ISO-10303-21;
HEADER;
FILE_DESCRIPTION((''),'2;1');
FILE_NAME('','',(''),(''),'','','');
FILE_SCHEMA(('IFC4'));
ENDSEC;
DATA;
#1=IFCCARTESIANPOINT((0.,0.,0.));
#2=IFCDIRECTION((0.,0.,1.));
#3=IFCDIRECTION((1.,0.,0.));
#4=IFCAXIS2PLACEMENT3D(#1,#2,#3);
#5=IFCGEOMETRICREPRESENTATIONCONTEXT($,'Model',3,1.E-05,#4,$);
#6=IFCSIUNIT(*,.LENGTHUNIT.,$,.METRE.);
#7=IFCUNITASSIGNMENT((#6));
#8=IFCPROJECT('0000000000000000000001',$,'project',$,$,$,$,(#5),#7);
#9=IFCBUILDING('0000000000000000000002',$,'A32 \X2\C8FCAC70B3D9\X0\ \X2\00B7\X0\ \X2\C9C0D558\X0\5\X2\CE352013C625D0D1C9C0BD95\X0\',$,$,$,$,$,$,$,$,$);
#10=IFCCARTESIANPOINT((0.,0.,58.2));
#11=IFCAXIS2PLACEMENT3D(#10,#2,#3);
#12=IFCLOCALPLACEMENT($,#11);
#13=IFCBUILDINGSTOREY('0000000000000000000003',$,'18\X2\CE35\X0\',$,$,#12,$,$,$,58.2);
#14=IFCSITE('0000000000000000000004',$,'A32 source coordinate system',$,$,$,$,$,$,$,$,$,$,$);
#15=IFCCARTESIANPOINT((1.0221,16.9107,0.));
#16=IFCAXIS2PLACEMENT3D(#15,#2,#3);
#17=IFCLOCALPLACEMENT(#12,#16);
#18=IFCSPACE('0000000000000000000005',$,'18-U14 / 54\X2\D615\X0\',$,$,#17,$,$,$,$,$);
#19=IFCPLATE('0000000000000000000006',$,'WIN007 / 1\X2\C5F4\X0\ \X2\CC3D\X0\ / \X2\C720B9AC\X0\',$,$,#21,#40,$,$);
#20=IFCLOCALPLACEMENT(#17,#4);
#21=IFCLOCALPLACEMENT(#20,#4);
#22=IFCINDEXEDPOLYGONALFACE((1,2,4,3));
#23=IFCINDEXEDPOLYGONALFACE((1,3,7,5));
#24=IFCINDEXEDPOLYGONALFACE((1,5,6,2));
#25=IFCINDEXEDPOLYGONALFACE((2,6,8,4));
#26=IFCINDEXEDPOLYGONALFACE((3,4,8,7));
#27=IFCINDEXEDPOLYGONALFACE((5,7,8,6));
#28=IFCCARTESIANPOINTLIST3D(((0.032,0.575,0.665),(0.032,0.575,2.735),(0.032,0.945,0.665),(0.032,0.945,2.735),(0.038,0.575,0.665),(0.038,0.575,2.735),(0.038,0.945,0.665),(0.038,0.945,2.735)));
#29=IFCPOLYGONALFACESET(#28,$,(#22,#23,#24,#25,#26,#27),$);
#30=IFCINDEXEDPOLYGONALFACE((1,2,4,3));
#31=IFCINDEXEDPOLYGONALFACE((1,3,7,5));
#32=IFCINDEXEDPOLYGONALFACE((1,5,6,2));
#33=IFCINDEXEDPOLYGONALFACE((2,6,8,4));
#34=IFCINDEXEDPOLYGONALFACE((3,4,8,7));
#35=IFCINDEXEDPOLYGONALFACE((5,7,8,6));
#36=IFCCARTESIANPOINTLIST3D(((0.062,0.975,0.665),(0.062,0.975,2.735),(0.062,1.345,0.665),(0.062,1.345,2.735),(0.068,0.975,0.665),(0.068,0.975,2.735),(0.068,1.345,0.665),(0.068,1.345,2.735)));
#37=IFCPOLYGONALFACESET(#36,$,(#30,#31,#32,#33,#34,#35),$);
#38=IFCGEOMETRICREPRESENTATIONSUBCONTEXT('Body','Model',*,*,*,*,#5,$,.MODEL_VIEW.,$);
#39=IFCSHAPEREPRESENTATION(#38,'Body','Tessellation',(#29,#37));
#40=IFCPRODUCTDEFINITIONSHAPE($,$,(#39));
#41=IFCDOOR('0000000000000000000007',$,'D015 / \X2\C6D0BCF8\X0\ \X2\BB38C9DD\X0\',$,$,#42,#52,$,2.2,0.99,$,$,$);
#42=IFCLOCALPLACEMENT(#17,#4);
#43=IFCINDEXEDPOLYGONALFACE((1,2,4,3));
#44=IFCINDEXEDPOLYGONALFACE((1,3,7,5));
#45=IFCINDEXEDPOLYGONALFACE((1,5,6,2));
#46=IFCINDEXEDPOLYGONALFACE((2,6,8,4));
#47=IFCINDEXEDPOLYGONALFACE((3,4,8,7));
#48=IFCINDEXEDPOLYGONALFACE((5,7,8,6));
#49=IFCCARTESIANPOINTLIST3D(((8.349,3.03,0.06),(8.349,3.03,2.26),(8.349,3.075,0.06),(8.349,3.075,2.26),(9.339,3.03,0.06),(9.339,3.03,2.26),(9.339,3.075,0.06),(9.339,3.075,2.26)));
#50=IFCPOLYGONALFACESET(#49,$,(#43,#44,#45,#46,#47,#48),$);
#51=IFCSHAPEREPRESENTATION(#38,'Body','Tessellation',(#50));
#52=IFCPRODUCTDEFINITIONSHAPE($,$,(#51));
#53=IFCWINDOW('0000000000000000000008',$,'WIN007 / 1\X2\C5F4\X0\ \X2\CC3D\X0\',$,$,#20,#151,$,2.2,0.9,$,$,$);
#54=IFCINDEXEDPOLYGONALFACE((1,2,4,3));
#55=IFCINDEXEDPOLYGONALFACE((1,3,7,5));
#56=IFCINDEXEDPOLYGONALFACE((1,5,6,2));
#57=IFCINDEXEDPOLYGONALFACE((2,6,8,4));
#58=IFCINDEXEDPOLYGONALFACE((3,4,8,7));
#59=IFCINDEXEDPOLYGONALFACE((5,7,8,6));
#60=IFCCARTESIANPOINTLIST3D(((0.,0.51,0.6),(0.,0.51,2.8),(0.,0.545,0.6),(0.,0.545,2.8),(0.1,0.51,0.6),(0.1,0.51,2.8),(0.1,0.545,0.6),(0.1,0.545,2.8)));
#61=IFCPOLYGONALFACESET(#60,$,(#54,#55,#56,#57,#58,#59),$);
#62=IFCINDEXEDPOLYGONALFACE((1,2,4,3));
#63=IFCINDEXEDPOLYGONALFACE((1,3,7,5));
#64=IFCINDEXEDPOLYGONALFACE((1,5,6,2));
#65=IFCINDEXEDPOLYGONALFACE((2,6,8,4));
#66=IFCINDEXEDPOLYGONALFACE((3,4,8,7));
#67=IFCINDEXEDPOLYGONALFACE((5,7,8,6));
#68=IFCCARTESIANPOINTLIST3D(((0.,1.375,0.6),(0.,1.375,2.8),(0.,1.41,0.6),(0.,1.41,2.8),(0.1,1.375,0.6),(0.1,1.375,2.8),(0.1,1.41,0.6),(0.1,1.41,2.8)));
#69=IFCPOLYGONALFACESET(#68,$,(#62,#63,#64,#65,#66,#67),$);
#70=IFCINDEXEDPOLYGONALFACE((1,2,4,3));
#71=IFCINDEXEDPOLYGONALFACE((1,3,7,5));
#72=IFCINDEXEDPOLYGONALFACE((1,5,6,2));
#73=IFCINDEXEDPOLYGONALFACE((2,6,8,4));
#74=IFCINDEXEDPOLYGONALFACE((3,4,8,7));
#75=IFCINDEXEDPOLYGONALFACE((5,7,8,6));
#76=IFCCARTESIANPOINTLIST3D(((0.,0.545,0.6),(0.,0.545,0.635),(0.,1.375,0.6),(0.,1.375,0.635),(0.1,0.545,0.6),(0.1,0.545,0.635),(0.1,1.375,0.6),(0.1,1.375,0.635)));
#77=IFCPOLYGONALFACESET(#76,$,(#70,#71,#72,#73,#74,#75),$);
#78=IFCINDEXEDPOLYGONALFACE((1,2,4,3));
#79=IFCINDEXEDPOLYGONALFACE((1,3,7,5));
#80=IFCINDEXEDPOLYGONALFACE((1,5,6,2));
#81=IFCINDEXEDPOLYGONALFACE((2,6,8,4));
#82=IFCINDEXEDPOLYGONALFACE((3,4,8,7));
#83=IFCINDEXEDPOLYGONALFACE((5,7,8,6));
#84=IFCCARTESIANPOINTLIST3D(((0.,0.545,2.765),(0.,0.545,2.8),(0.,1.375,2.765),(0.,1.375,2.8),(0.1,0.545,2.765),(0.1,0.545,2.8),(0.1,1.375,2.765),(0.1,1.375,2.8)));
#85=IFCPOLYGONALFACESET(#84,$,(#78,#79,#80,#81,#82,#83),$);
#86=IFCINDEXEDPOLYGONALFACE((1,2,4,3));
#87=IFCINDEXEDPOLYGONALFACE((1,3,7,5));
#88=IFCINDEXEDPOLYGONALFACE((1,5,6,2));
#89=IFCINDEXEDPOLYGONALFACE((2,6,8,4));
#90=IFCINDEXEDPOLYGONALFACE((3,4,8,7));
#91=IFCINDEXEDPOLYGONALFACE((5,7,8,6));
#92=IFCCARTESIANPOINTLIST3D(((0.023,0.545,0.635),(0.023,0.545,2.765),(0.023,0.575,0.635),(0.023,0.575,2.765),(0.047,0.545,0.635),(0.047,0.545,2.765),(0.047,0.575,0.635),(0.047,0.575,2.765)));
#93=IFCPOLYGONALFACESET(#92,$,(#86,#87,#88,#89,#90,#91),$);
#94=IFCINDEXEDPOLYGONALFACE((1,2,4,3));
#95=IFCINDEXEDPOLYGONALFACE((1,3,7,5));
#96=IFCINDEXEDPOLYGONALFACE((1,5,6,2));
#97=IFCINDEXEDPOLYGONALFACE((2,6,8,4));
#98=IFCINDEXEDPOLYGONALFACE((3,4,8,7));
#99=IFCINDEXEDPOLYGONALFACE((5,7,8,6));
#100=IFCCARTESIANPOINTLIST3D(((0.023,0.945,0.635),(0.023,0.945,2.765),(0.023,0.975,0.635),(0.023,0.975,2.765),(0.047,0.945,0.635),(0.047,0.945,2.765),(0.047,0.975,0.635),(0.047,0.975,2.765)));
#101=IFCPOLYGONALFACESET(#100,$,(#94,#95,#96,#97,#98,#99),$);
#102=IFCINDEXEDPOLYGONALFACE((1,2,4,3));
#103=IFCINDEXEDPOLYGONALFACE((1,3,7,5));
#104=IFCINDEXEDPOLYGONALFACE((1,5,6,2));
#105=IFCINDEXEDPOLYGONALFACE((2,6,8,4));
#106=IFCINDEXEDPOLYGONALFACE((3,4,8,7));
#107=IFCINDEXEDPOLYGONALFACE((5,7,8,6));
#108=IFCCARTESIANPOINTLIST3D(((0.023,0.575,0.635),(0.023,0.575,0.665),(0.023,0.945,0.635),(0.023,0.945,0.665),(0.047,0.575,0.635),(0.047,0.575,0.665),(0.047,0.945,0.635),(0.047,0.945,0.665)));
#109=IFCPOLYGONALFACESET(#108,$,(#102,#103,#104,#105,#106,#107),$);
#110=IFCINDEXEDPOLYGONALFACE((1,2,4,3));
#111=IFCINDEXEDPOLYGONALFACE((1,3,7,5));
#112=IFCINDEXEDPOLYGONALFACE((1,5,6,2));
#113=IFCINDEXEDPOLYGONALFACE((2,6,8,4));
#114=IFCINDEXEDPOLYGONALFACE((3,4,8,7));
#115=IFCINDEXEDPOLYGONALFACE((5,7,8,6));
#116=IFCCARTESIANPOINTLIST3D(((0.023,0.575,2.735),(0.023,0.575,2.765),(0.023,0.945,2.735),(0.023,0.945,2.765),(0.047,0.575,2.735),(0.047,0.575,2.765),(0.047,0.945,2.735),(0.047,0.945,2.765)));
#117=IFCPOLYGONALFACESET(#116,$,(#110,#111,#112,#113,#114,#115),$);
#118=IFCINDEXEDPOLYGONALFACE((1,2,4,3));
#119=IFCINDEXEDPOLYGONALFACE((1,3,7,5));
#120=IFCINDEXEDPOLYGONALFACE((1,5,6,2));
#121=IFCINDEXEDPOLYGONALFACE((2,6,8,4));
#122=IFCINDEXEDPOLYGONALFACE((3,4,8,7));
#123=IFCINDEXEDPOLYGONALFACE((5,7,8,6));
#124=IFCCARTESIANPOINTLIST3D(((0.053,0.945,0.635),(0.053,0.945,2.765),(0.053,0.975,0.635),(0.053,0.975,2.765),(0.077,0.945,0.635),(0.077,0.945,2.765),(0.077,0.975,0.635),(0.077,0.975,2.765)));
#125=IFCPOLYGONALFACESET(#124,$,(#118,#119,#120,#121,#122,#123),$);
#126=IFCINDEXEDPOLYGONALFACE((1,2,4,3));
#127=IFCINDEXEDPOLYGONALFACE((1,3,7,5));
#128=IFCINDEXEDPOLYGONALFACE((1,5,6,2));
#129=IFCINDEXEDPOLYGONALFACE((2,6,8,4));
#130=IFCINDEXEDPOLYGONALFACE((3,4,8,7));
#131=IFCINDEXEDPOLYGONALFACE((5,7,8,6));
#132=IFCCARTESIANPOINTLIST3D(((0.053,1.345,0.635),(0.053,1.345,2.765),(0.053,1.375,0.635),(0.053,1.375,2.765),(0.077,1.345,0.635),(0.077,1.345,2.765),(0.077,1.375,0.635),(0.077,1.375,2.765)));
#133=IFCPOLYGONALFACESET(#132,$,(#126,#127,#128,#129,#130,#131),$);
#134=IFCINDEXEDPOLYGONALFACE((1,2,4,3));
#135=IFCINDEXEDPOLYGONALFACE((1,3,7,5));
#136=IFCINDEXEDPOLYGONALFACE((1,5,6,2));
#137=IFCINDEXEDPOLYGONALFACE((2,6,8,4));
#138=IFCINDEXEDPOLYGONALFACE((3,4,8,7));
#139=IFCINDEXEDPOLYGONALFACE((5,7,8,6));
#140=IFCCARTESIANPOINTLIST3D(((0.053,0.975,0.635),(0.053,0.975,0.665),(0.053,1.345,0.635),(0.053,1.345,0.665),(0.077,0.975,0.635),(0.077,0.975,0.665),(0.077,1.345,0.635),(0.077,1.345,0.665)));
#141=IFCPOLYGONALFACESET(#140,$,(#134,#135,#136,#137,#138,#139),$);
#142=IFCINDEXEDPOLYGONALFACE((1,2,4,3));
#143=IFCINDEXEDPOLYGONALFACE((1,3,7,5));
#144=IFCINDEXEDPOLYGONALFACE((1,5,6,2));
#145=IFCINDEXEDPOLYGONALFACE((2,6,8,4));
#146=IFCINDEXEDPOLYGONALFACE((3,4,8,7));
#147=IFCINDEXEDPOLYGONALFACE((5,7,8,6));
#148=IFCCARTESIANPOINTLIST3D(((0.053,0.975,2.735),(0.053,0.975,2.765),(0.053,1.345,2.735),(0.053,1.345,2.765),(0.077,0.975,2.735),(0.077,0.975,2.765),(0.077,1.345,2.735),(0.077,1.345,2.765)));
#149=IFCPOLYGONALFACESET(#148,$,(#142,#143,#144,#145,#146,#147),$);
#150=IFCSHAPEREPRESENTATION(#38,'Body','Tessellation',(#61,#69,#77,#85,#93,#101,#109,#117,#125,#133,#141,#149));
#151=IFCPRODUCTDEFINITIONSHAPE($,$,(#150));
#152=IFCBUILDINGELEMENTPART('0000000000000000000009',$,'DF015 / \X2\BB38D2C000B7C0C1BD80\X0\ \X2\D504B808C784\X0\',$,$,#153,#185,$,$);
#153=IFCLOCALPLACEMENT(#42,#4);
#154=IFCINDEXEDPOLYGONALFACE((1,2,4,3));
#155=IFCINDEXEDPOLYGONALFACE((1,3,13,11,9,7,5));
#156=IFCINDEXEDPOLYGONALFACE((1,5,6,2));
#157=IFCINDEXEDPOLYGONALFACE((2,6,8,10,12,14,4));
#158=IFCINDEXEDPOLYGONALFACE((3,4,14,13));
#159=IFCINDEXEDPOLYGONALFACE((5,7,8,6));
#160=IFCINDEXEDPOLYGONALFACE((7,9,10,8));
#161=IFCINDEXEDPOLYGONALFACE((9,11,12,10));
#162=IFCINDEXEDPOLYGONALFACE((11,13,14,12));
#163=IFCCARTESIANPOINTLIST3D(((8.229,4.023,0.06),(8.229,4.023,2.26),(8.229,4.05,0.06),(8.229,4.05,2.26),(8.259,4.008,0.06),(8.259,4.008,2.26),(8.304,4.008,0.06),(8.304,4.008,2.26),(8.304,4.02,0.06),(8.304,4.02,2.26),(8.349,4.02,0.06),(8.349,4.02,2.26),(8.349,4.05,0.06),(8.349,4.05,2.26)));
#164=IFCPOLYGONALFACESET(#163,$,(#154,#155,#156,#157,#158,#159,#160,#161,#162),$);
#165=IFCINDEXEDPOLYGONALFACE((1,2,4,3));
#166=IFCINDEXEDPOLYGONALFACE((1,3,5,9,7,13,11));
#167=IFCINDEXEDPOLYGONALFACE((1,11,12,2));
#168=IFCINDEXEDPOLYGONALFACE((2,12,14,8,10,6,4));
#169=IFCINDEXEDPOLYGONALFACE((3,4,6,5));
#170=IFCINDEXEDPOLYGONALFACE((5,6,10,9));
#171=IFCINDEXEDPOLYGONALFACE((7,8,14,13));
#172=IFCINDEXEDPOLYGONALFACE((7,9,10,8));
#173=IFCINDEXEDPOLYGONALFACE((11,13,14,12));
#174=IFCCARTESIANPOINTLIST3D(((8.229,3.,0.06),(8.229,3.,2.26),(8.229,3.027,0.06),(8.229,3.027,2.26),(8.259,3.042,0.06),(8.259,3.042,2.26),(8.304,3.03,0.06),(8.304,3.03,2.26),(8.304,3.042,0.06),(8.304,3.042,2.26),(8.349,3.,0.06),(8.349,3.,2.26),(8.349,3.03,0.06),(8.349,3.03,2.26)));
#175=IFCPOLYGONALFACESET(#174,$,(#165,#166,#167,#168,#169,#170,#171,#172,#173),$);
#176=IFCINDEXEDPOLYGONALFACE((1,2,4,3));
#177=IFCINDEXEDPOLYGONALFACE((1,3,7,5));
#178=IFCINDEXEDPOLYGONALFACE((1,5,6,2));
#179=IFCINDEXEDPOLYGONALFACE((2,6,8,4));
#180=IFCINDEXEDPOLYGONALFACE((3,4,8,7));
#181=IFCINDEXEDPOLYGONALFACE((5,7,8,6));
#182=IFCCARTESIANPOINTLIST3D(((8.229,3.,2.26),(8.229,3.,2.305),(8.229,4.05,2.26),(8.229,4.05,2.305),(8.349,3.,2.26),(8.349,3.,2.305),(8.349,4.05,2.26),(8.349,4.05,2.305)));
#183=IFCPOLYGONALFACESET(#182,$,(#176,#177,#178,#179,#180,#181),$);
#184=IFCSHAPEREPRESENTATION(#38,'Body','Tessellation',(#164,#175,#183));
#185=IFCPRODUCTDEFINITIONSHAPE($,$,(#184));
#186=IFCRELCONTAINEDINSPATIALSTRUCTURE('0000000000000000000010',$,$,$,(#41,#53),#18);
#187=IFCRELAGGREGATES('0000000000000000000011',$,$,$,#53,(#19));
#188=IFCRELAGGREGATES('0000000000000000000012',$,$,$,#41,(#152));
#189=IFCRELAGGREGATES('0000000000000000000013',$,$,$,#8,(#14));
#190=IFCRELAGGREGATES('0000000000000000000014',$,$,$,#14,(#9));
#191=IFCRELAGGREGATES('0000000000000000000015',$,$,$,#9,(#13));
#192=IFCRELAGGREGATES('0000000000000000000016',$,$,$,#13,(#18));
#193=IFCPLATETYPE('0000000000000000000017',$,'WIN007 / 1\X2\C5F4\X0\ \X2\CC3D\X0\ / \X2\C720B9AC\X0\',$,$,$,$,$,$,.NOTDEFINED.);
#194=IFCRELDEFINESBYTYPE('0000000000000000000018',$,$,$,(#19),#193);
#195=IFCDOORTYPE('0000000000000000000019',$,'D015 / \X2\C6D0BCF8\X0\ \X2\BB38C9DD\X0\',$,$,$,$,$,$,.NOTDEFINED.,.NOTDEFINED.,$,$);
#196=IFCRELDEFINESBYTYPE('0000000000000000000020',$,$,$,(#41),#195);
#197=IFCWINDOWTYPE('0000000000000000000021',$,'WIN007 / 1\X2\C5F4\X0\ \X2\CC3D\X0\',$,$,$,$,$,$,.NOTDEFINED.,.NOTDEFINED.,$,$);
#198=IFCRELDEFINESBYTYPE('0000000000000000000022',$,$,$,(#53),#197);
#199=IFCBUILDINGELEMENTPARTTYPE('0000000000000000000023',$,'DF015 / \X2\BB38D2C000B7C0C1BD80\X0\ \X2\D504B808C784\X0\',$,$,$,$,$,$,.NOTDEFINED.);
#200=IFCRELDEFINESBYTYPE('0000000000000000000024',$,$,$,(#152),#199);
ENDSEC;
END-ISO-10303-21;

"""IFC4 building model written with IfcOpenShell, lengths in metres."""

from ifc_helpers import new_model, si_unit, frame, origin, origin_with_axes, place, context, subcontext, project, spatial, polyline, outline, extrude, source, transform, mapped, type_object, type_shapes, element, aggregate, save


model = new_model("IFC4")

# Units and contexts
model_context = context("Model", 3, precision=1e-05, world=origin_with_axes())
body_context = subcontext(model_context, "Body", "Model", "MODEL_VIEW")
ifc_project = project(units=[si_unit("LENGTHUNIT", "METRE")], contexts=[model_context])

# Plate
plate_type_1 = type_object("IfcPlateType", Name="WIN007 / 1열 창 / 유리", PredefinedType="NOTDEFINED")
shared_shape_1 = source(origin(), body_context, "Body", "SweptSolid", [
    extrude(outline(polyline([(0.032, 0.575), (0.032, 0.945), (0.038, 0.945), (0.038, 0.575), (0.032, 0.575)])), frame((0.0, 0.0, 0.665)), (0.0, 0.0, 1.0), 2.07),
    extrude(outline(polyline([(0.062, 0.975), (0.062, 1.345), (0.068, 1.345), (0.068, 0.975), (0.062, 0.975)])), frame((0.0, 0.0, 0.665)), (0.0, 0.0, 1.0), 2.07),
])
type_shapes(plate_type_1, [shared_shape_1])
storey_placement = place(None, frame((0.0, 0.0, 58.2), z_axis=(0.0, 0.0, 1.0), x_axis=(1.0, 0.0, 0.0)))
space_1_placement = place(storey_placement, frame((1.0221, 16.9107, 0.0), z_axis=(0.0, 0.0, 1.0), x_axis=(1.0, 0.0, 0.0)))
window_1_placement = place(space_1_placement, origin_with_axes())
plate_1_placement = place(window_1_placement, origin_with_axes())
plate_1 = element("IfcPlate", 1, at=plate_1_placement, type_object=plate_type_1, Name="WIN007 / 1열 창 / 유리", context=body_context, shape_type="MappedRepresentation", body=[
    mapped(shared_shape_1, transform((0.0, 0.0, 0.0), scale=1.0)),
])

# Site, building, storey, space
site = spatial("IfcSite", under=ifc_project, Name="A32 source coordinate system")
building = spatial("IfcBuilding", under=site, Name="A32 주거동 · 지하5층–옥탑지붕")
storey = spatial("IfcBuildingStorey", under=building, at=storey_placement, Name="18층", Elevation=58.2)
space_1 = spatial("IfcSpace", under=storey, at=space_1_placement, Name="18-U14 / 54형")

# Door
door_type_1 = type_object("IfcDoorType", Name="D015 / 원본 문짝", OperationType="NOTDEFINED", PredefinedType="NOTDEFINED")
shared_shape_2 = source(origin(), body_context, "Body", "SweptSolid", [
    extrude(outline(polyline([(9.339, 3.075), (9.339, 3.03), (8.349, 3.03), (8.349, 3.075), (9.339, 3.075)])), frame((0.0, 0.0, 0.06)), (0.0, 0.0, 1.0), 2.2),
])
type_shapes(door_type_1, [shared_shape_2])
door_1_placement = place(space_1_placement, origin_with_axes())
door_1 = element("IfcDoor", 2, at=door_1_placement, inside=space_1, type_object=door_type_1, Name="D015 / 원본 문짝", OverallHeight=2.2, OverallWidth=0.99, context=body_context, shape_type="MappedRepresentation", body=[
    mapped(shared_shape_2, transform((0.0, 0.0, 0.0), scale=1.0)),
])

# Window
window_type_1 = type_object("IfcWindowType", Name="WIN007 / 1열 창", PartitioningType="NOTDEFINED", PredefinedType="NOTDEFINED")
shared_shape_3 = source(origin(), body_context, "Body", "SweptSolid", [
    extrude(outline(polyline([(0.0, 0.51), (0.0, 0.545), (0.1, 0.545), (0.1, 0.51), (0.0, 0.51)])), frame((0.0, 0.0, 0.6)), (0.0, 0.0, 1.0), 2.2),
    extrude(outline(polyline([(0.0, 1.375), (0.0, 1.41), (0.1, 1.41), (0.1, 1.375), (0.0, 1.375)])), frame((0.0, 0.0, 0.6)), (0.0, 0.0, 1.0), 2.2),
    extrude(outline(polyline([(0.0, 0.545), (0.0, 1.375), (0.1, 1.375), (0.1, 0.545), (0.0, 0.545)])), frame((0.0, 0.0, 0.6)), (0.0, 0.0, 1.0), 0.035),
    extrude(outline(polyline([(0.0, 0.545), (0.0, 1.375), (0.1, 1.375), (0.1, 0.545), (0.0, 0.545)])), frame((0.0, 0.0, 2.765)), (0.0, 0.0, 1.0), 0.035),
    extrude(outline(polyline([(0.023, 0.545), (0.023, 0.575), (0.047, 0.575), (0.047, 0.545), (0.023, 0.545)])), frame((0.0, 0.0, 0.635)), (0.0, 0.0, 1.0), 2.13),
    extrude(outline(polyline([(0.023, 0.945), (0.023, 0.975), (0.047, 0.975), (0.047, 0.945), (0.023, 0.945)])), frame((0.0, 0.0, 0.635)), (0.0, 0.0, 1.0), 2.13),
    extrude(outline(polyline([(0.023, 0.575), (0.023, 0.945), (0.047, 0.945), (0.047, 0.575), (0.023, 0.575)])), frame((0.0, 0.0, 0.635)), (0.0, 0.0, 1.0), 0.03),
    extrude(outline(polyline([(0.023, 0.575), (0.023, 0.945), (0.047, 0.945), (0.047, 0.575), (0.023, 0.575)])), frame((0.0, 0.0, 2.735)), (0.0, 0.0, 1.0), 0.03),
    extrude(outline(polyline([(0.053, 0.945), (0.053, 0.975), (0.077, 0.975), (0.077, 0.945), (0.053, 0.945)])), frame((0.0, 0.0, 0.635)), (0.0, 0.0, 1.0), 2.13),
    extrude(outline(polyline([(0.053, 1.345), (0.053, 1.375), (0.077, 1.375), (0.077, 1.345), (0.053, 1.345)])), frame((0.0, 0.0, 0.635)), (0.0, 0.0, 1.0), 2.13),
    extrude(outline(polyline([(0.053, 0.975), (0.053, 1.345), (0.077, 1.345), (0.077, 0.975), (0.053, 0.975)])), frame((0.0, 0.0, 0.635)), (0.0, 0.0, 1.0), 0.03),
    extrude(outline(polyline([(0.053, 0.975), (0.053, 1.345), (0.077, 1.345), (0.077, 0.975), (0.053, 0.975)])), frame((0.0, 0.0, 2.735)), (0.0, 0.0, 1.0), 0.03),
])
type_shapes(window_type_1, [shared_shape_3])
window_1 = element("IfcWindow", 3, at=window_1_placement, inside=space_1, type_object=window_type_1, Name="WIN007 / 1열 창", OverallHeight=2.2, OverallWidth=0.9, context=body_context, shape_type="MappedRepresentation", body=[
    mapped(shared_shape_3, transform((0.0, 0.0, 0.0), scale=1.0)),
])
aggregate(window_1, [plate_1])

# Building element part
building_element_part_type_1 = type_object("IfcBuildingElementPartType", Name="DF015 / 문틀·상부 프레임", PredefinedType="NOTDEFINED")
shared_shape_4 = source(origin(), body_context, "Body", "SweptSolid", [
    extrude(outline(polyline([(8.349, 4.02), (8.304, 4.02), (8.304, 4.008), (8.259, 4.008), (8.229, 4.023), (8.229, 4.05), (8.349, 4.05), (8.349, 4.02)])), frame((0.0, 0.0, 0.06)), (0.0, 0.0, 1.0), 2.2),
    extrude(outline(polyline([(8.229, 3.0), (8.229, 3.027), (8.259, 3.042), (8.304, 3.042), (8.304, 3.03), (8.349, 3.03), (8.349, 3.0), (8.229, 3.0)])), frame((0.0, 0.0, 0.06)), (0.0, 0.0, 1.0), 2.2),
    extrude(outline(polyline([(8.229, 3.0), (8.229, 4.05), (8.349, 4.05), (8.349, 3.0), (8.229, 3.0)])), frame((0.0, 0.0, 2.26)), (0.0, 0.0, 1.0), 0.045),
])
type_shapes(building_element_part_type_1, [shared_shape_4])
building_element_part_1_placement = place(door_1_placement, origin_with_axes())
building_element_part_1 = element("IfcBuildingElementPart", 4, at=building_element_part_1_placement, type_object=building_element_part_type_1, Name="DF015 / 문틀·상부 프레임", context=body_context, shape_type="MappedRepresentation", body=[
    mapped(shared_shape_4, transform((0.0, 0.0, 0.0), scale=1.0)),
])
aggregate(door_1, [building_element_part_1])

save(model, "model.ifc")
